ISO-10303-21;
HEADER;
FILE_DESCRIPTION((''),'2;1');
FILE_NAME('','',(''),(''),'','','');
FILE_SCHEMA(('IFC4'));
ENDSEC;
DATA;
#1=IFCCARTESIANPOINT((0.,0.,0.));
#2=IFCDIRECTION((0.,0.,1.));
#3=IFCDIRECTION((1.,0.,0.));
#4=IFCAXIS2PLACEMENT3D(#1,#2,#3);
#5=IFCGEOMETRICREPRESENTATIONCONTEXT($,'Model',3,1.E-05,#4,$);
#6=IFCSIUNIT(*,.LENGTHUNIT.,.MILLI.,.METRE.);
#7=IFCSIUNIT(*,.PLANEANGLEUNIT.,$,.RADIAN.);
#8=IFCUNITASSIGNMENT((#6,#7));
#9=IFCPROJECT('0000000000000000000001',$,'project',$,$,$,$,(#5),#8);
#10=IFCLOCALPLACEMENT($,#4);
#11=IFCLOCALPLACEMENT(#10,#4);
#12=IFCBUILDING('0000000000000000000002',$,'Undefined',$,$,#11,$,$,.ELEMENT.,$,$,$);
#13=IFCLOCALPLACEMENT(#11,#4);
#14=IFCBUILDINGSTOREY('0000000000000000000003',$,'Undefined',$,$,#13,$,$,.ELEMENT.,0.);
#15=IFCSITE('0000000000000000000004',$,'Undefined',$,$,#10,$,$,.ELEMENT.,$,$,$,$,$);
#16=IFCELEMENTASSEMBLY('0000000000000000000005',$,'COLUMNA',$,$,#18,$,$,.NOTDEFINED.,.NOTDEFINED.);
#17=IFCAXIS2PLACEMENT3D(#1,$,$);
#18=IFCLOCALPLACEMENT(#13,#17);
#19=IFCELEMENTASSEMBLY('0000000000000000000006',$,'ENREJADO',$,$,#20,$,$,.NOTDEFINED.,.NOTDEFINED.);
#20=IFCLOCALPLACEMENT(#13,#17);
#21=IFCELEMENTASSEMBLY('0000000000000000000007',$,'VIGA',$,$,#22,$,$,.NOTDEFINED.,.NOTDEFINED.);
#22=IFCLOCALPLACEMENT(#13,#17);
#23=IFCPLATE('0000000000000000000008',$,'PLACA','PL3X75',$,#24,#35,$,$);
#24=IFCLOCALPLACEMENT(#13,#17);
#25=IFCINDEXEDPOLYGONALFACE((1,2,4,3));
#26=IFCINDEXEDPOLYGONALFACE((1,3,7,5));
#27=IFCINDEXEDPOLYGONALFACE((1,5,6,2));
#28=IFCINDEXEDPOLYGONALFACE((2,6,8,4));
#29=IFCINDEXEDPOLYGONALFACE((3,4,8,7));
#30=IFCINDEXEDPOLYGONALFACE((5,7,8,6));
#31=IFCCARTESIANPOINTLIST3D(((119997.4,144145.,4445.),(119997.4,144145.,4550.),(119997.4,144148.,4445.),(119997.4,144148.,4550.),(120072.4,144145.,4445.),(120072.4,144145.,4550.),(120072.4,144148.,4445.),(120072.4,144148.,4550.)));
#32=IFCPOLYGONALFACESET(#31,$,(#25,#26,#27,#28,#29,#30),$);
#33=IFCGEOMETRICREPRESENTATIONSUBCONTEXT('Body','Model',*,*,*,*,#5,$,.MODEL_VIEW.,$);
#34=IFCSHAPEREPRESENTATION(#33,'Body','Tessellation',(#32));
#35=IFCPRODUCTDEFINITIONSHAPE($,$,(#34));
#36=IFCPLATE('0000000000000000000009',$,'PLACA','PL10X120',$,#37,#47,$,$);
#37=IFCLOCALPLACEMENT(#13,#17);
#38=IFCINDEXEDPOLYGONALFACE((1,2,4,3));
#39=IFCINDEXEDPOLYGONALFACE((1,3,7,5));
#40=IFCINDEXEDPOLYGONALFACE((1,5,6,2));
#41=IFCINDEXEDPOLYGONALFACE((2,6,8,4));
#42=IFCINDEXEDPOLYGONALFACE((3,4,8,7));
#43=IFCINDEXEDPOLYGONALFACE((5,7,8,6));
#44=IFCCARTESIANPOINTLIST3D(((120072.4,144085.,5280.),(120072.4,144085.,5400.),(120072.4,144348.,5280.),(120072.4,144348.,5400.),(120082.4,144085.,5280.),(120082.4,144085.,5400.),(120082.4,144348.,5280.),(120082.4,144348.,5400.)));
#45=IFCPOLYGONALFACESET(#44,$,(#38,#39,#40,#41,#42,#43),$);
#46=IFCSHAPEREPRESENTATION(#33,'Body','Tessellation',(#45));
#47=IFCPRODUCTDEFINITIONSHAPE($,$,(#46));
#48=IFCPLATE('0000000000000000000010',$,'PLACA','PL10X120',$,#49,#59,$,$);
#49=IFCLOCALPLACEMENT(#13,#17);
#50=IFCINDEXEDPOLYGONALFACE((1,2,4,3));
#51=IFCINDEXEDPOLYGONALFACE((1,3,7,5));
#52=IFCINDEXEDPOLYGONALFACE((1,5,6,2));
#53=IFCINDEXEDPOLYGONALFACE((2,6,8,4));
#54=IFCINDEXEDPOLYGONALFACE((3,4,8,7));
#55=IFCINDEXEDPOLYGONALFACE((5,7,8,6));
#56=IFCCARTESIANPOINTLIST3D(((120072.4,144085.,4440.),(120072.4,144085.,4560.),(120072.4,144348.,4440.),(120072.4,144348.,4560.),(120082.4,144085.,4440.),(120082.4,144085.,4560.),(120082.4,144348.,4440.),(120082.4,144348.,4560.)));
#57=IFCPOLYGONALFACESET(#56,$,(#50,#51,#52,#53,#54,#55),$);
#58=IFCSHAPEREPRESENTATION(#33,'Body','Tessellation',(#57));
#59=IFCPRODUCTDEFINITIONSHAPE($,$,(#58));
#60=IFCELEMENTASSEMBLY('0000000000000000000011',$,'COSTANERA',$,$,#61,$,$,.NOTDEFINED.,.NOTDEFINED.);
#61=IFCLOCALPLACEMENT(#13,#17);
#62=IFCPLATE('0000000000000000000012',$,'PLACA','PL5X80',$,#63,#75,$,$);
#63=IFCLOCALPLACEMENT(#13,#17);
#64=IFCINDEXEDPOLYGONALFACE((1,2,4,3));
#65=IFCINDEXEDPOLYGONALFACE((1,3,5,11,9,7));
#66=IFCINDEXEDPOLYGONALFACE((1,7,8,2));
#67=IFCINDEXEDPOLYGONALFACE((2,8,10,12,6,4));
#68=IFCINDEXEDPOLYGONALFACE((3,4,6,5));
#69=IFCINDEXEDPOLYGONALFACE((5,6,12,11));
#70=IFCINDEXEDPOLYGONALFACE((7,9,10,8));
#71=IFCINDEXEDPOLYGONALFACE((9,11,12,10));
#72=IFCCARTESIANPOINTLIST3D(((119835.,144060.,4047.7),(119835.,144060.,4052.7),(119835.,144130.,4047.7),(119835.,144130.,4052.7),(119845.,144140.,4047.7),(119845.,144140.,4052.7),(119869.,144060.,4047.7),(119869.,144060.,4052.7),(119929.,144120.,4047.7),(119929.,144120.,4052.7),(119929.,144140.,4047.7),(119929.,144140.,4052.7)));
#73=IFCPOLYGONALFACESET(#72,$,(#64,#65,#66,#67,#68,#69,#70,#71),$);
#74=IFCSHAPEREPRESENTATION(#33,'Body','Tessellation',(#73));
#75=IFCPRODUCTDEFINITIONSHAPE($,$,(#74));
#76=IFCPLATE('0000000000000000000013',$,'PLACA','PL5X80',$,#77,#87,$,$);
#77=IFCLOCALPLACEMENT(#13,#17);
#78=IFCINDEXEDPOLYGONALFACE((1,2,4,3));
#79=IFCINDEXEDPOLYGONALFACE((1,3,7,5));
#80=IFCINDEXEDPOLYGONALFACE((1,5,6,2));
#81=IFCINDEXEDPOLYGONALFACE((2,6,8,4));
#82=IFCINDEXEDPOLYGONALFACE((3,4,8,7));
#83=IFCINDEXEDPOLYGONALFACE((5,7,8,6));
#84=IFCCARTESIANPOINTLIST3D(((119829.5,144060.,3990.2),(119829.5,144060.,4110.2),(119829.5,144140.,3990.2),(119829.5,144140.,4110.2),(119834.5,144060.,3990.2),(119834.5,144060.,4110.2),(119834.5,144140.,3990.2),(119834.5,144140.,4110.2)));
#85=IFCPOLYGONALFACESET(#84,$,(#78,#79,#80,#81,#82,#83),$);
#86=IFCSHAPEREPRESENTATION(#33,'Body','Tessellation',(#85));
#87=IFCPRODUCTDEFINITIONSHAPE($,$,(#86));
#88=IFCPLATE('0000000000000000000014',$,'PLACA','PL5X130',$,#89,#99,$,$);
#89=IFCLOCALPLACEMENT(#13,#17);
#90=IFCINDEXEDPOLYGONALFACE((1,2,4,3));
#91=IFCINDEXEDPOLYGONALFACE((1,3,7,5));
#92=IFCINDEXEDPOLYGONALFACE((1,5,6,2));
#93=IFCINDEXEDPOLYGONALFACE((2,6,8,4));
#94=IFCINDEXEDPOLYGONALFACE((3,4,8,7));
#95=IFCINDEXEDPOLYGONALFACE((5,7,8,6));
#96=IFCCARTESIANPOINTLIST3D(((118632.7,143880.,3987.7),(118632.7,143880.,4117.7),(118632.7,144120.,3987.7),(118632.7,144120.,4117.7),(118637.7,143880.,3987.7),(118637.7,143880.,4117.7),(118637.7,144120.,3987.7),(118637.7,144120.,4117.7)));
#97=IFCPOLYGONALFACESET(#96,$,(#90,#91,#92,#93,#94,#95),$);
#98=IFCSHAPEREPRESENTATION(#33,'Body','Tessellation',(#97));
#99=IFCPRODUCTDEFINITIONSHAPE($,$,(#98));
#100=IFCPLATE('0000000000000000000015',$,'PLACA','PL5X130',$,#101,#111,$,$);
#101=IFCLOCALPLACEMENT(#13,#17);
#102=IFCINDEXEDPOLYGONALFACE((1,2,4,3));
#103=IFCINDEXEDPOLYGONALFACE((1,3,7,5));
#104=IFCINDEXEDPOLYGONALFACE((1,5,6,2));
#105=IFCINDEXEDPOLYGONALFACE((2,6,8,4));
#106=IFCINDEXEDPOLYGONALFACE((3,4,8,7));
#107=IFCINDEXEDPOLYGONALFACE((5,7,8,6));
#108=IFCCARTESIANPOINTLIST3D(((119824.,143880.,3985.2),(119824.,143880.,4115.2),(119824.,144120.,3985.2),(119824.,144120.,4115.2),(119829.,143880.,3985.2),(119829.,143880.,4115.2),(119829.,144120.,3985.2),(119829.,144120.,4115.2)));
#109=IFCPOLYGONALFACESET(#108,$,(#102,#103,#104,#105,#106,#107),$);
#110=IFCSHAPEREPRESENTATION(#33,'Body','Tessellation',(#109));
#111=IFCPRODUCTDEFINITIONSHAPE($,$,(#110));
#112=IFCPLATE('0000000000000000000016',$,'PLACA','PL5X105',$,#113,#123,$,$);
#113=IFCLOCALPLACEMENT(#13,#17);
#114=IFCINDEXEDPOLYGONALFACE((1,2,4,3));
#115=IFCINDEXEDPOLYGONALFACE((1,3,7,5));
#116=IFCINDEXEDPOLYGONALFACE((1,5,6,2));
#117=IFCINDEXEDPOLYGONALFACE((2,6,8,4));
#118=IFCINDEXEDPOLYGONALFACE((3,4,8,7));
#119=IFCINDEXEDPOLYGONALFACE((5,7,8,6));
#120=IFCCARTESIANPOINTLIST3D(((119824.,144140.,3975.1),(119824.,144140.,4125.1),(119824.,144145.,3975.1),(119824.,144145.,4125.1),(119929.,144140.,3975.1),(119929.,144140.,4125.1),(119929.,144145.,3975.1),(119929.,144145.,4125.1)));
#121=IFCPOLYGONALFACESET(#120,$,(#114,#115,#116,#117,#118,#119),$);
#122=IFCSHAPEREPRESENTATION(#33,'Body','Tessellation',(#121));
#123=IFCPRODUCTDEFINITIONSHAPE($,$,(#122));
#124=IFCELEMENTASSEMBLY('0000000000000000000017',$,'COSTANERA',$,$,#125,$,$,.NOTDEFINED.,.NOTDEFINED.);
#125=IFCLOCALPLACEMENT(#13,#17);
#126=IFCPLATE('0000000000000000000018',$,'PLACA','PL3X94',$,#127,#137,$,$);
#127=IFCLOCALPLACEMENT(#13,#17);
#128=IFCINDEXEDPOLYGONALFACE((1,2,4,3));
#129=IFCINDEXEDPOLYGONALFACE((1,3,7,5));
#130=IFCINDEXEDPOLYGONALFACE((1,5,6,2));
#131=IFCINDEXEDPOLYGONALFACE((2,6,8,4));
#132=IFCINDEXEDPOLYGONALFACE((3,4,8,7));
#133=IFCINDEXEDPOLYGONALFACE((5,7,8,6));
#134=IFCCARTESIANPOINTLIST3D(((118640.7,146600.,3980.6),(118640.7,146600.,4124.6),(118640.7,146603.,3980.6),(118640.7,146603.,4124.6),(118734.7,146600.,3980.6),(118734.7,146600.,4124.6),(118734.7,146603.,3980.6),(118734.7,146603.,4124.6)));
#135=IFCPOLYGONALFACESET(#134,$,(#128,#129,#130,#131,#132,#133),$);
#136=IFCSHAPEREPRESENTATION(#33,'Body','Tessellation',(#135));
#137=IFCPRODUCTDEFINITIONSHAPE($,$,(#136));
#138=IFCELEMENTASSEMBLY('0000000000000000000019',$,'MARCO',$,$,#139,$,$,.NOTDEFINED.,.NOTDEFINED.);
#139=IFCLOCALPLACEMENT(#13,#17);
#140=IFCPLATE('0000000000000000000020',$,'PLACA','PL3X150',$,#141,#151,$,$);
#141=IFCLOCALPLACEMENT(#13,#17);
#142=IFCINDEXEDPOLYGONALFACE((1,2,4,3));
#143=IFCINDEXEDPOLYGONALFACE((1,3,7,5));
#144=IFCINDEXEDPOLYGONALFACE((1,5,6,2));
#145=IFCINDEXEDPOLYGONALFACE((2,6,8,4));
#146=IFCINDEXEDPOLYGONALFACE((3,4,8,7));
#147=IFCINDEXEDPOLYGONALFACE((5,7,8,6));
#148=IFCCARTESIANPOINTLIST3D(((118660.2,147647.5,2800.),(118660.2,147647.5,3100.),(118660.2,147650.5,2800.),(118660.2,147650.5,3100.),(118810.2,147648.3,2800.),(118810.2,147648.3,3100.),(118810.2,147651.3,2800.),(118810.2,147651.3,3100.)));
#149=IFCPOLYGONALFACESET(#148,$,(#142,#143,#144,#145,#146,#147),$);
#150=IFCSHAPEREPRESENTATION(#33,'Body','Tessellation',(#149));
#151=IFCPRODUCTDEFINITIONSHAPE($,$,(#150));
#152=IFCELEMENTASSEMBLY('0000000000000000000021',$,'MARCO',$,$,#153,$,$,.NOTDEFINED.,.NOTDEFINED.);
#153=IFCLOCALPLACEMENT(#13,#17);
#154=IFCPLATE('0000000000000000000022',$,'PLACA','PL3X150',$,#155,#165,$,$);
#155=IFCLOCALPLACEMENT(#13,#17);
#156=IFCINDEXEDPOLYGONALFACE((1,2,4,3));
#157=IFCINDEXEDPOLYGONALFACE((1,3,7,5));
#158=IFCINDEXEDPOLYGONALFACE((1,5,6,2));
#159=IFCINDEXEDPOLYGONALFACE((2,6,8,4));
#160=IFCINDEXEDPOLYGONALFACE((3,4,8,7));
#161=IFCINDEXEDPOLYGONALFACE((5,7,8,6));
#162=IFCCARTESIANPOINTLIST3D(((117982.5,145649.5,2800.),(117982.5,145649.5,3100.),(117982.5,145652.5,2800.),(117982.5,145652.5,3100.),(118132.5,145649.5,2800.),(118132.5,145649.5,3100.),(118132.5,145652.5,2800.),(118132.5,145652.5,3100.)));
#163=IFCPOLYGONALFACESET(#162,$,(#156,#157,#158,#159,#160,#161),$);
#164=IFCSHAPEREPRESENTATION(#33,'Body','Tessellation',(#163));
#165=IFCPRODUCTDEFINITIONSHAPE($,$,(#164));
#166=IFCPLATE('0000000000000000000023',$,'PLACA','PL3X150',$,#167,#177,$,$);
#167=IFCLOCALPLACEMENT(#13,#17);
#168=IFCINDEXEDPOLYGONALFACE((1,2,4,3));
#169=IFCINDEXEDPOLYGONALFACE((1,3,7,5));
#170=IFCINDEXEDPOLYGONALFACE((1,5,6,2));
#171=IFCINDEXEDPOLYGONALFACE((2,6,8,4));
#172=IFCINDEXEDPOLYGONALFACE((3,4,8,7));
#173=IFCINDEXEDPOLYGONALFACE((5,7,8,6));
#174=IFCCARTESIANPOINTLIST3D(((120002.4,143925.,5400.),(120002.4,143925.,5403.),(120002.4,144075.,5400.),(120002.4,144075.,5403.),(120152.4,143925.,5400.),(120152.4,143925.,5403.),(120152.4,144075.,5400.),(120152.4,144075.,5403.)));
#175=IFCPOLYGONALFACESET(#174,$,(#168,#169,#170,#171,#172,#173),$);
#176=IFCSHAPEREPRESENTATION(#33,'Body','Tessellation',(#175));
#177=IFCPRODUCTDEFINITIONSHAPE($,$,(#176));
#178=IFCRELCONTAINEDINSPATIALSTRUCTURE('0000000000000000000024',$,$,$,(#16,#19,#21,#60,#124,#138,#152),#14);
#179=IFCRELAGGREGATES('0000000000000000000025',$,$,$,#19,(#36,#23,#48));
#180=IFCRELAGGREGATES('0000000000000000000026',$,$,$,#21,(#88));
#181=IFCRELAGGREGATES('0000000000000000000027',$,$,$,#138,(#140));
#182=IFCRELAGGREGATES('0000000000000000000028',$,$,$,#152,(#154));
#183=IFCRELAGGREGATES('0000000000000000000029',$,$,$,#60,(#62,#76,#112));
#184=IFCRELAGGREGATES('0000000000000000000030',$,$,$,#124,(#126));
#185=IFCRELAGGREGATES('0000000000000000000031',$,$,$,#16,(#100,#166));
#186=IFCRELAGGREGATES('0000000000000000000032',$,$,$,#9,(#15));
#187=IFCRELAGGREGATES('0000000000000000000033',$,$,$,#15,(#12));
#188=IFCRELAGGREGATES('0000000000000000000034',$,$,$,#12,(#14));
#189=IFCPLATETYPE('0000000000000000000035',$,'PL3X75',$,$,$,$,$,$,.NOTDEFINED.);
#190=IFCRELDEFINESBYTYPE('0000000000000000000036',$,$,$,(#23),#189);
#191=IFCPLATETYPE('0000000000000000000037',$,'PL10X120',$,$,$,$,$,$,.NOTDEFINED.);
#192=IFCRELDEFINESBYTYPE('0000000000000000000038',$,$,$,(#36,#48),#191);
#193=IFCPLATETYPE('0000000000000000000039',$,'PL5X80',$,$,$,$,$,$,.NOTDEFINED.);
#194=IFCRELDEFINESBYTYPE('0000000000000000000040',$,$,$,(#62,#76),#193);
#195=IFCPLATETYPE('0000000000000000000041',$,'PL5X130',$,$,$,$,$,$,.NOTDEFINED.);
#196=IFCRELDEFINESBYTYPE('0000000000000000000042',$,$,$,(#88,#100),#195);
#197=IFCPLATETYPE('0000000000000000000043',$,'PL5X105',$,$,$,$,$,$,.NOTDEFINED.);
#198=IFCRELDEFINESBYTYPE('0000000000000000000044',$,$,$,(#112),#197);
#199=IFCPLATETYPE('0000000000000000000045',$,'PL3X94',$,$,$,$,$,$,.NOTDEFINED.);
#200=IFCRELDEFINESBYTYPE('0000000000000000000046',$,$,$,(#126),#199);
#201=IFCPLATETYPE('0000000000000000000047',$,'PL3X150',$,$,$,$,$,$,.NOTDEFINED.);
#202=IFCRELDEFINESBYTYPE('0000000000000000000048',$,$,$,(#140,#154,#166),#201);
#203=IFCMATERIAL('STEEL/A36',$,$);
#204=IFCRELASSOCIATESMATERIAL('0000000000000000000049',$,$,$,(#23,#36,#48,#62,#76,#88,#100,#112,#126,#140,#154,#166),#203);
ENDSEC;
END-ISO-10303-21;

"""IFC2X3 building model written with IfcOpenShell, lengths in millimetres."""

from ifc_helpers import new_model, si_unit, frame, origin_with_axes, place, context, subcontext, project, spatial, polyline, outline, extrude, material, type_object, element, aggregate, save


model = new_model("IFC2X3")

# Units and contexts
model_context = context("Model", 3, precision=1e-05, world=origin_with_axes())
body_context = subcontext(model_context, "Body", "Model", "MODEL_VIEW")
ifc_project = project(units=[si_unit("LENGTHUNIT", "METRE", prefix="MILLI"), si_unit("PLANEANGLEUNIT", "RADIAN")], contexts=[model_context])

# Site, building, storey
site_placement = place(None, origin_with_axes())
site = spatial("IfcSite", under=ifc_project, at=site_placement, Name="Undefined", CompositionType="ELEMENT")
building_placement = place(site_placement, origin_with_axes())
building = spatial("IfcBuilding", under=site, at=building_placement, Name="Undefined", CompositionType="ELEMENT")
storey_placement = place(building_placement, origin_with_axes())
storey = spatial("IfcBuildingStorey", under=building, at=storey_placement, Name="Undefined", CompositionType="ELEMENT", Elevation=0.0)

# Element assemblies
assembly_1_placement = place(storey_placement, origin_with_axes())
assembly_1 = element("IfcElementAssembly", 1, at=assembly_1_placement, inside=storey, Name="COLUMNA", AssemblyPlace="NOTDEFINED", PredefinedType="NOTDEFINED")
assembly_2_placement = place(storey_placement, origin_with_axes())
assembly_2 = element("IfcElementAssembly", 2, at=assembly_2_placement, inside=storey, Name="ENREJADO", AssemblyPlace="NOTDEFINED", PredefinedType="NOTDEFINED")
ifc_material_1 = material(Name="STEEL/A36")

# Element assembly
assembly_3_placement = place(storey_placement, origin_with_axes())
assembly_3 = element("IfcElementAssembly", 3, at=assembly_3_placement, inside=storey, Name="VIGA", AssemblyPlace="NOTDEFINED", PredefinedType="NOTDEFINED")

# Plates
plate_type_1 = type_object("IfcPlateType", Name="PL3X75", PredefinedType="NOTDEFINED")
plate_1_placement = place(assembly_2_placement, frame((120072.4, 144146.5, 4445.0), z_axis=(0.0, 1.0, 0.0), x_axis=(-1.0, 0.0, 0.0)))
plate_1 = element("IfcPlate", 4, at=plate_1_placement, type_object=plate_type_1, material=ifc_material_1, Name="PLACA", Description="PL3X75", context=body_context, shape_type="SweptSolid", body=[
    extrude(outline(polyline([(0.0, 0.0), (75.0, 0.0), (75.0, 105.0), (0.0, 105.0), (0.0, 0.0)])), frame((0.0, 0.0, -1.5), z_axis=(0.0, 0.0, 1.0), x_axis=(1.0, 0.0, 0.0)), (0.0, 0.0, 1.0), 3.0),
])
plate_type_2 = type_object("IfcPlateType", Name="PL10X120", PredefinedType="NOTDEFINED")
plate_2_placement = place(assembly_2_placement, frame((120077.4, 144085.0, 5340.0), z_axis=(-1.0, 0.0, 0.0), x_axis=(0.0, 1.0, 0.0)))
plate_2 = element("IfcPlate", 5, at=plate_2_placement, type_object=plate_type_2, material=ifc_material_1, Name="PLACA", Description="PL10X120", context=body_context, shape_type="SweptSolid", body=[
    extrude(outline(polyline([(0.0, -60.0), (0.0, 60.0), (263.0, 60.0), (263.0, -60.0), (0.0, -60.0)])), frame((0.0, 0.0, -5.0), z_axis=(0.0, 0.0, 1.0), x_axis=(1.0, 0.0, 0.0)), (0.0, 0.0, 1.0), 10.0),
])
plate_3_placement = place(assembly_2_placement, frame((120077.4, 144085.0, 4500.0), z_axis=(-1.0, 0.0, 0.0), x_axis=(0.0, 1.0, 0.0)))
plate_3 = element("IfcPlate", 6, at=plate_3_placement, type_object=plate_type_2, material=ifc_material_1, Name="PLACA", Description="PL10X120", context=body_context, shape_type="SweptSolid", body=[
    extrude(outline(polyline([(0.0, -60.0), (0.0, 60.0), (263.0, 60.0), (263.0, -60.0), (0.0, -60.0)])), frame((0.0, 0.0, -5.0), z_axis=(0.0, 0.0, 1.0), x_axis=(1.0, 0.0, 0.0)), (0.0, 0.0, 1.0), 10.0),
])
aggregate(assembly_2, [plate_2, plate_1, plate_3])

# Element assembly, plates
assembly_4_placement = place(storey_placement, origin_with_axes())
assembly_4 = element("IfcElementAssembly", 7, at=assembly_4_placement, inside=storey, Name="COSTANERA", AssemblyPlace="NOTDEFINED", PredefinedType="NOTDEFINED")
plate_type_3 = type_object("IfcPlateType", Name="PL5X80", PredefinedType="NOTDEFINED")
plate_4_placement = place(assembly_4_placement, frame((119835.0, 144060.0, 4050.2), z_axis=(0.0, 0.0, -1.0), x_axis=(0.0, 1.0, 0.0)))
plate_4 = element("IfcPlate", 8, at=plate_4_placement, type_object=plate_type_3, material=ifc_material_1, Name="PLACA", Description="PL5X80", context=body_context, shape_type="SweptSolid", body=[
    extrude(outline(polyline([(0.0, 0.0), (70.0, 0.0), (80.0, 10.0), (80.0, 94.0), (60.0, 94.0), (0.0, 34.0), (0.0, 0.0)])), frame((0.0, 0.0, -2.5), z_axis=(0.0, 0.0, 1.0), x_axis=(1.0, 0.0, 0.0)), (0.0, 0.0, 1.0), 5.0),
])
plate_5_placement = place(assembly_4_placement, frame((119832.0, 144060.0, 4110.2), z_axis=(-1.0, 0.0, 0.0), x_axis=(0.0, 1.0, 0.0)))
plate_5 = element("IfcPlate", 9, at=plate_5_placement, type_object=plate_type_3, material=ifc_material_1, Name="PLACA", Description="PL5X80", context=body_context, shape_type="SweptSolid", body=[
    extrude(outline(polyline([(0.0, 0.0), (80.0, 0.0), (80.0, 120.0), (0.0, 120.0), (0.0, 0.0)])), frame((0.0, 0.0, -2.5), z_axis=(0.0, 0.0, 1.0), x_axis=(1.0, 0.0, 0.0)), (0.0, 0.0, 1.0), 5.0),
])

# Plates
plate_type_4 = type_object("IfcPlateType", Name="PL5X130", PredefinedType="NOTDEFINED")
plate_6_placement = place(assembly_3_placement, frame((118635.2, 144120.0, 4117.7), z_axis=(1.0, 0.0, 0.0), x_axis=(0.0, -1.0, 0.000006)))
plate_6 = element("IfcPlate", 10, at=plate_6_placement, type_object=plate_type_4, material=ifc_material_1, Name="PLACA", Description="PL5X130", context=body_context, shape_type="SweptSolid", body=[
    extrude(outline(polyline([(0.0, 0.0), (240.0, 0.0), (240.0, 130.0), (0.0, 130.0), (0.0, 0.0)])), frame((0.0, 0.0, -2.5), z_axis=(0.0, 0.0, 1.0), x_axis=(1.0, 0.0, 0.0)), (0.0, 0.0, 1.0), 5.0),
])
aggregate(assembly_3, [plate_6])
plate_7_placement = place(assembly_1_placement, frame((119826.5, 144120.0, 4115.2), z_axis=(1.0, 0.0, 0.0), x_axis=(0.0, -1.0, 0.0)))
plate_7 = element("IfcPlate", 11, at=plate_7_placement, type_object=plate_type_4, material=ifc_material_1, Name="PLACA", Description="PL5X130", context=body_context, shape_type="SweptSolid", body=[
    extrude(outline(polyline([(0.0, 0.0), (240.0, 0.0), (240.0, 130.0), (0.0, 130.0), (0.0, 0.0)])), frame((0.0, 0.0, -2.5), z_axis=(0.0, 0.0, 1.0), x_axis=(1.0, 0.0, 0.0)), (0.0, 0.0, 1.0), 5.0),
])
plate_type_5 = type_object("IfcPlateType", Name="PL5X105", PredefinedType="NOTDEFINED")
plate_8_placement = place(assembly_4_placement, frame((119929.0, 144142.5, 3975.1), z_axis=(0.0, 1.0, 0.0), x_axis=(-1.0, 0.0, 0.0)))
plate_8 = element("IfcPlate", 12, at=plate_8_placement, type_object=plate_type_5, material=ifc_material_1, Name="PLACA", Description="PL5X105", context=body_context, shape_type="SweptSolid", body=[
    extrude(outline(polyline([(0.0, 0.0), (105.0, 0.0), (105.0, 150.0), (0.0, 150.0), (0.0, 0.0)])), frame((0.0, 0.0, -2.5), z_axis=(0.0, 0.0, 1.0), x_axis=(1.0, 0.0, 0.0)), (0.0, 0.0, 1.0), 5.0),
])

# Element assemblies, plates
assembly_5_placement = place(storey_placement, origin_with_axes())
assembly_5 = element("IfcElementAssembly", 13, at=assembly_5_placement, inside=storey, Name="COSTANERA", AssemblyPlace="NOTDEFINED", PredefinedType="NOTDEFINED")
plate_type_6 = type_object("IfcPlateType", Name="PL3X94", PredefinedType="NOTDEFINED")
plate_9_placement = place(assembly_5_placement, frame((118734.7, 146601.5, 4124.6), z_axis=(0.0, -1.0, 0.0), x_axis=(-1.0, 0.0, 0.0)))
plate_9 = element("IfcPlate", 14, at=plate_9_placement, type_object=plate_type_6, material=ifc_material_1, Name="PLACA", Description="PL3X94", context=body_context, shape_type="SweptSolid", body=[
    extrude(outline(polyline([(0.0, 0.0), (94.0, 0.0), (94.0, 144.0), (0.0, 144.0), (0.0, 0.0)])), frame((0.0, 0.0, -1.5), z_axis=(0.0, 0.0, 1.0), x_axis=(1.0, 0.0, 0.0)), (0.0, 0.0, 1.0), 3.0),
])
assembly_6_placement = place(storey_placement, origin_with_axes())
assembly_6 = element("IfcElementAssembly", 15, at=assembly_6_placement, inside=storey, Name="MARCO", AssemblyPlace="NOTDEFINED", PredefinedType="NOTDEFINED")
plate_type_7 = type_object("IfcPlateType", Name="PL3X150", PredefinedType="NOTDEFINED")
plate_10_placement = place(assembly_6_placement, frame((118660.2, 147649.0, 3100.0), z_axis=(-0.005406, 0.999985, 0.0), x_axis=(0.999985, 0.005406, 0.0)))
plate_10 = element("IfcPlate", 16, at=plate_10_placement, type_object=plate_type_7, material=ifc_material_1, Name="PLACA", Description="PL3X150", context=body_context, shape_type="SweptSolid", body=[
    extrude(outline(polyline([(0.0, 0.0), (150.0, 0.0), (150.0, 300.0), (0.0, 300.0), (0.0, 0.0)])), frame((0.0, 0.0, -1.5), z_axis=(0.0, 0.0, 1.0), x_axis=(1.0, 0.0, 0.0)), (0.0, 0.0, 1.0), 3.0),
])
aggregate(assembly_6, [plate_10])
assembly_7_placement = place(storey_placement, origin_with_axes())
assembly_7 = element("IfcElementAssembly", 17, at=assembly_7_placement, inside=storey, Name="MARCO", AssemblyPlace="NOTDEFINED", PredefinedType="NOTDEFINED")
plate_11_placement = place(assembly_7_placement, frame((118132.5, 145651.0, 3100.0), z_axis=(-0.000439, -1.0, 0.0), x_axis=(-1.0, 0.000439, 0.0)))
plate_11 = element("IfcPlate", 18, at=plate_11_placement, type_object=plate_type_7, material=ifc_material_1, Name="PLACA", Description="PL3X150", context=body_context, shape_type="SweptSolid", body=[
    extrude(outline(polyline([(0.0, 0.0), (150.0, 0.0), (150.0, 300.0), (0.0, 300.0), (0.0, 0.0)])), frame((0.0, 0.0, -1.5), z_axis=(0.0, 0.0, 1.0), x_axis=(1.0, 0.0, 0.0)), (0.0, 0.0, 1.0), 3.0),
])
aggregate(assembly_7, [plate_11])

# Plate
plate_12_placement = place(assembly_1_placement, frame((120152.4, 144075.0, 5401.5), z_axis=(0.0, 0.0, -1.0), x_axis=(0.0, -1.0, 0.0)))
plate_12 = element("IfcPlate", 19, at=plate_12_placement, type_object=plate_type_7, material=ifc_material_1, Name="PLACA", Description="PL3X150", context=body_context, shape_type="SweptSolid", body=[
    extrude(outline(polyline([(0.0, 0.0), (150.0, 0.0), (150.0, 150.0), (0.0, 150.0), (0.0, 0.0)])), frame((0.0, 0.0, -1.5), z_axis=(0.0, 0.0, 1.0), x_axis=(1.0, 0.0, 0.0)), (0.0, 0.0, 1.0), 3.0),
])

aggregate(assembly_4, [plate_4, plate_5, plate_8])
aggregate(assembly_5, [plate_9])
aggregate(assembly_1, [plate_7, plate_12])

save(model, "model.ifc")
